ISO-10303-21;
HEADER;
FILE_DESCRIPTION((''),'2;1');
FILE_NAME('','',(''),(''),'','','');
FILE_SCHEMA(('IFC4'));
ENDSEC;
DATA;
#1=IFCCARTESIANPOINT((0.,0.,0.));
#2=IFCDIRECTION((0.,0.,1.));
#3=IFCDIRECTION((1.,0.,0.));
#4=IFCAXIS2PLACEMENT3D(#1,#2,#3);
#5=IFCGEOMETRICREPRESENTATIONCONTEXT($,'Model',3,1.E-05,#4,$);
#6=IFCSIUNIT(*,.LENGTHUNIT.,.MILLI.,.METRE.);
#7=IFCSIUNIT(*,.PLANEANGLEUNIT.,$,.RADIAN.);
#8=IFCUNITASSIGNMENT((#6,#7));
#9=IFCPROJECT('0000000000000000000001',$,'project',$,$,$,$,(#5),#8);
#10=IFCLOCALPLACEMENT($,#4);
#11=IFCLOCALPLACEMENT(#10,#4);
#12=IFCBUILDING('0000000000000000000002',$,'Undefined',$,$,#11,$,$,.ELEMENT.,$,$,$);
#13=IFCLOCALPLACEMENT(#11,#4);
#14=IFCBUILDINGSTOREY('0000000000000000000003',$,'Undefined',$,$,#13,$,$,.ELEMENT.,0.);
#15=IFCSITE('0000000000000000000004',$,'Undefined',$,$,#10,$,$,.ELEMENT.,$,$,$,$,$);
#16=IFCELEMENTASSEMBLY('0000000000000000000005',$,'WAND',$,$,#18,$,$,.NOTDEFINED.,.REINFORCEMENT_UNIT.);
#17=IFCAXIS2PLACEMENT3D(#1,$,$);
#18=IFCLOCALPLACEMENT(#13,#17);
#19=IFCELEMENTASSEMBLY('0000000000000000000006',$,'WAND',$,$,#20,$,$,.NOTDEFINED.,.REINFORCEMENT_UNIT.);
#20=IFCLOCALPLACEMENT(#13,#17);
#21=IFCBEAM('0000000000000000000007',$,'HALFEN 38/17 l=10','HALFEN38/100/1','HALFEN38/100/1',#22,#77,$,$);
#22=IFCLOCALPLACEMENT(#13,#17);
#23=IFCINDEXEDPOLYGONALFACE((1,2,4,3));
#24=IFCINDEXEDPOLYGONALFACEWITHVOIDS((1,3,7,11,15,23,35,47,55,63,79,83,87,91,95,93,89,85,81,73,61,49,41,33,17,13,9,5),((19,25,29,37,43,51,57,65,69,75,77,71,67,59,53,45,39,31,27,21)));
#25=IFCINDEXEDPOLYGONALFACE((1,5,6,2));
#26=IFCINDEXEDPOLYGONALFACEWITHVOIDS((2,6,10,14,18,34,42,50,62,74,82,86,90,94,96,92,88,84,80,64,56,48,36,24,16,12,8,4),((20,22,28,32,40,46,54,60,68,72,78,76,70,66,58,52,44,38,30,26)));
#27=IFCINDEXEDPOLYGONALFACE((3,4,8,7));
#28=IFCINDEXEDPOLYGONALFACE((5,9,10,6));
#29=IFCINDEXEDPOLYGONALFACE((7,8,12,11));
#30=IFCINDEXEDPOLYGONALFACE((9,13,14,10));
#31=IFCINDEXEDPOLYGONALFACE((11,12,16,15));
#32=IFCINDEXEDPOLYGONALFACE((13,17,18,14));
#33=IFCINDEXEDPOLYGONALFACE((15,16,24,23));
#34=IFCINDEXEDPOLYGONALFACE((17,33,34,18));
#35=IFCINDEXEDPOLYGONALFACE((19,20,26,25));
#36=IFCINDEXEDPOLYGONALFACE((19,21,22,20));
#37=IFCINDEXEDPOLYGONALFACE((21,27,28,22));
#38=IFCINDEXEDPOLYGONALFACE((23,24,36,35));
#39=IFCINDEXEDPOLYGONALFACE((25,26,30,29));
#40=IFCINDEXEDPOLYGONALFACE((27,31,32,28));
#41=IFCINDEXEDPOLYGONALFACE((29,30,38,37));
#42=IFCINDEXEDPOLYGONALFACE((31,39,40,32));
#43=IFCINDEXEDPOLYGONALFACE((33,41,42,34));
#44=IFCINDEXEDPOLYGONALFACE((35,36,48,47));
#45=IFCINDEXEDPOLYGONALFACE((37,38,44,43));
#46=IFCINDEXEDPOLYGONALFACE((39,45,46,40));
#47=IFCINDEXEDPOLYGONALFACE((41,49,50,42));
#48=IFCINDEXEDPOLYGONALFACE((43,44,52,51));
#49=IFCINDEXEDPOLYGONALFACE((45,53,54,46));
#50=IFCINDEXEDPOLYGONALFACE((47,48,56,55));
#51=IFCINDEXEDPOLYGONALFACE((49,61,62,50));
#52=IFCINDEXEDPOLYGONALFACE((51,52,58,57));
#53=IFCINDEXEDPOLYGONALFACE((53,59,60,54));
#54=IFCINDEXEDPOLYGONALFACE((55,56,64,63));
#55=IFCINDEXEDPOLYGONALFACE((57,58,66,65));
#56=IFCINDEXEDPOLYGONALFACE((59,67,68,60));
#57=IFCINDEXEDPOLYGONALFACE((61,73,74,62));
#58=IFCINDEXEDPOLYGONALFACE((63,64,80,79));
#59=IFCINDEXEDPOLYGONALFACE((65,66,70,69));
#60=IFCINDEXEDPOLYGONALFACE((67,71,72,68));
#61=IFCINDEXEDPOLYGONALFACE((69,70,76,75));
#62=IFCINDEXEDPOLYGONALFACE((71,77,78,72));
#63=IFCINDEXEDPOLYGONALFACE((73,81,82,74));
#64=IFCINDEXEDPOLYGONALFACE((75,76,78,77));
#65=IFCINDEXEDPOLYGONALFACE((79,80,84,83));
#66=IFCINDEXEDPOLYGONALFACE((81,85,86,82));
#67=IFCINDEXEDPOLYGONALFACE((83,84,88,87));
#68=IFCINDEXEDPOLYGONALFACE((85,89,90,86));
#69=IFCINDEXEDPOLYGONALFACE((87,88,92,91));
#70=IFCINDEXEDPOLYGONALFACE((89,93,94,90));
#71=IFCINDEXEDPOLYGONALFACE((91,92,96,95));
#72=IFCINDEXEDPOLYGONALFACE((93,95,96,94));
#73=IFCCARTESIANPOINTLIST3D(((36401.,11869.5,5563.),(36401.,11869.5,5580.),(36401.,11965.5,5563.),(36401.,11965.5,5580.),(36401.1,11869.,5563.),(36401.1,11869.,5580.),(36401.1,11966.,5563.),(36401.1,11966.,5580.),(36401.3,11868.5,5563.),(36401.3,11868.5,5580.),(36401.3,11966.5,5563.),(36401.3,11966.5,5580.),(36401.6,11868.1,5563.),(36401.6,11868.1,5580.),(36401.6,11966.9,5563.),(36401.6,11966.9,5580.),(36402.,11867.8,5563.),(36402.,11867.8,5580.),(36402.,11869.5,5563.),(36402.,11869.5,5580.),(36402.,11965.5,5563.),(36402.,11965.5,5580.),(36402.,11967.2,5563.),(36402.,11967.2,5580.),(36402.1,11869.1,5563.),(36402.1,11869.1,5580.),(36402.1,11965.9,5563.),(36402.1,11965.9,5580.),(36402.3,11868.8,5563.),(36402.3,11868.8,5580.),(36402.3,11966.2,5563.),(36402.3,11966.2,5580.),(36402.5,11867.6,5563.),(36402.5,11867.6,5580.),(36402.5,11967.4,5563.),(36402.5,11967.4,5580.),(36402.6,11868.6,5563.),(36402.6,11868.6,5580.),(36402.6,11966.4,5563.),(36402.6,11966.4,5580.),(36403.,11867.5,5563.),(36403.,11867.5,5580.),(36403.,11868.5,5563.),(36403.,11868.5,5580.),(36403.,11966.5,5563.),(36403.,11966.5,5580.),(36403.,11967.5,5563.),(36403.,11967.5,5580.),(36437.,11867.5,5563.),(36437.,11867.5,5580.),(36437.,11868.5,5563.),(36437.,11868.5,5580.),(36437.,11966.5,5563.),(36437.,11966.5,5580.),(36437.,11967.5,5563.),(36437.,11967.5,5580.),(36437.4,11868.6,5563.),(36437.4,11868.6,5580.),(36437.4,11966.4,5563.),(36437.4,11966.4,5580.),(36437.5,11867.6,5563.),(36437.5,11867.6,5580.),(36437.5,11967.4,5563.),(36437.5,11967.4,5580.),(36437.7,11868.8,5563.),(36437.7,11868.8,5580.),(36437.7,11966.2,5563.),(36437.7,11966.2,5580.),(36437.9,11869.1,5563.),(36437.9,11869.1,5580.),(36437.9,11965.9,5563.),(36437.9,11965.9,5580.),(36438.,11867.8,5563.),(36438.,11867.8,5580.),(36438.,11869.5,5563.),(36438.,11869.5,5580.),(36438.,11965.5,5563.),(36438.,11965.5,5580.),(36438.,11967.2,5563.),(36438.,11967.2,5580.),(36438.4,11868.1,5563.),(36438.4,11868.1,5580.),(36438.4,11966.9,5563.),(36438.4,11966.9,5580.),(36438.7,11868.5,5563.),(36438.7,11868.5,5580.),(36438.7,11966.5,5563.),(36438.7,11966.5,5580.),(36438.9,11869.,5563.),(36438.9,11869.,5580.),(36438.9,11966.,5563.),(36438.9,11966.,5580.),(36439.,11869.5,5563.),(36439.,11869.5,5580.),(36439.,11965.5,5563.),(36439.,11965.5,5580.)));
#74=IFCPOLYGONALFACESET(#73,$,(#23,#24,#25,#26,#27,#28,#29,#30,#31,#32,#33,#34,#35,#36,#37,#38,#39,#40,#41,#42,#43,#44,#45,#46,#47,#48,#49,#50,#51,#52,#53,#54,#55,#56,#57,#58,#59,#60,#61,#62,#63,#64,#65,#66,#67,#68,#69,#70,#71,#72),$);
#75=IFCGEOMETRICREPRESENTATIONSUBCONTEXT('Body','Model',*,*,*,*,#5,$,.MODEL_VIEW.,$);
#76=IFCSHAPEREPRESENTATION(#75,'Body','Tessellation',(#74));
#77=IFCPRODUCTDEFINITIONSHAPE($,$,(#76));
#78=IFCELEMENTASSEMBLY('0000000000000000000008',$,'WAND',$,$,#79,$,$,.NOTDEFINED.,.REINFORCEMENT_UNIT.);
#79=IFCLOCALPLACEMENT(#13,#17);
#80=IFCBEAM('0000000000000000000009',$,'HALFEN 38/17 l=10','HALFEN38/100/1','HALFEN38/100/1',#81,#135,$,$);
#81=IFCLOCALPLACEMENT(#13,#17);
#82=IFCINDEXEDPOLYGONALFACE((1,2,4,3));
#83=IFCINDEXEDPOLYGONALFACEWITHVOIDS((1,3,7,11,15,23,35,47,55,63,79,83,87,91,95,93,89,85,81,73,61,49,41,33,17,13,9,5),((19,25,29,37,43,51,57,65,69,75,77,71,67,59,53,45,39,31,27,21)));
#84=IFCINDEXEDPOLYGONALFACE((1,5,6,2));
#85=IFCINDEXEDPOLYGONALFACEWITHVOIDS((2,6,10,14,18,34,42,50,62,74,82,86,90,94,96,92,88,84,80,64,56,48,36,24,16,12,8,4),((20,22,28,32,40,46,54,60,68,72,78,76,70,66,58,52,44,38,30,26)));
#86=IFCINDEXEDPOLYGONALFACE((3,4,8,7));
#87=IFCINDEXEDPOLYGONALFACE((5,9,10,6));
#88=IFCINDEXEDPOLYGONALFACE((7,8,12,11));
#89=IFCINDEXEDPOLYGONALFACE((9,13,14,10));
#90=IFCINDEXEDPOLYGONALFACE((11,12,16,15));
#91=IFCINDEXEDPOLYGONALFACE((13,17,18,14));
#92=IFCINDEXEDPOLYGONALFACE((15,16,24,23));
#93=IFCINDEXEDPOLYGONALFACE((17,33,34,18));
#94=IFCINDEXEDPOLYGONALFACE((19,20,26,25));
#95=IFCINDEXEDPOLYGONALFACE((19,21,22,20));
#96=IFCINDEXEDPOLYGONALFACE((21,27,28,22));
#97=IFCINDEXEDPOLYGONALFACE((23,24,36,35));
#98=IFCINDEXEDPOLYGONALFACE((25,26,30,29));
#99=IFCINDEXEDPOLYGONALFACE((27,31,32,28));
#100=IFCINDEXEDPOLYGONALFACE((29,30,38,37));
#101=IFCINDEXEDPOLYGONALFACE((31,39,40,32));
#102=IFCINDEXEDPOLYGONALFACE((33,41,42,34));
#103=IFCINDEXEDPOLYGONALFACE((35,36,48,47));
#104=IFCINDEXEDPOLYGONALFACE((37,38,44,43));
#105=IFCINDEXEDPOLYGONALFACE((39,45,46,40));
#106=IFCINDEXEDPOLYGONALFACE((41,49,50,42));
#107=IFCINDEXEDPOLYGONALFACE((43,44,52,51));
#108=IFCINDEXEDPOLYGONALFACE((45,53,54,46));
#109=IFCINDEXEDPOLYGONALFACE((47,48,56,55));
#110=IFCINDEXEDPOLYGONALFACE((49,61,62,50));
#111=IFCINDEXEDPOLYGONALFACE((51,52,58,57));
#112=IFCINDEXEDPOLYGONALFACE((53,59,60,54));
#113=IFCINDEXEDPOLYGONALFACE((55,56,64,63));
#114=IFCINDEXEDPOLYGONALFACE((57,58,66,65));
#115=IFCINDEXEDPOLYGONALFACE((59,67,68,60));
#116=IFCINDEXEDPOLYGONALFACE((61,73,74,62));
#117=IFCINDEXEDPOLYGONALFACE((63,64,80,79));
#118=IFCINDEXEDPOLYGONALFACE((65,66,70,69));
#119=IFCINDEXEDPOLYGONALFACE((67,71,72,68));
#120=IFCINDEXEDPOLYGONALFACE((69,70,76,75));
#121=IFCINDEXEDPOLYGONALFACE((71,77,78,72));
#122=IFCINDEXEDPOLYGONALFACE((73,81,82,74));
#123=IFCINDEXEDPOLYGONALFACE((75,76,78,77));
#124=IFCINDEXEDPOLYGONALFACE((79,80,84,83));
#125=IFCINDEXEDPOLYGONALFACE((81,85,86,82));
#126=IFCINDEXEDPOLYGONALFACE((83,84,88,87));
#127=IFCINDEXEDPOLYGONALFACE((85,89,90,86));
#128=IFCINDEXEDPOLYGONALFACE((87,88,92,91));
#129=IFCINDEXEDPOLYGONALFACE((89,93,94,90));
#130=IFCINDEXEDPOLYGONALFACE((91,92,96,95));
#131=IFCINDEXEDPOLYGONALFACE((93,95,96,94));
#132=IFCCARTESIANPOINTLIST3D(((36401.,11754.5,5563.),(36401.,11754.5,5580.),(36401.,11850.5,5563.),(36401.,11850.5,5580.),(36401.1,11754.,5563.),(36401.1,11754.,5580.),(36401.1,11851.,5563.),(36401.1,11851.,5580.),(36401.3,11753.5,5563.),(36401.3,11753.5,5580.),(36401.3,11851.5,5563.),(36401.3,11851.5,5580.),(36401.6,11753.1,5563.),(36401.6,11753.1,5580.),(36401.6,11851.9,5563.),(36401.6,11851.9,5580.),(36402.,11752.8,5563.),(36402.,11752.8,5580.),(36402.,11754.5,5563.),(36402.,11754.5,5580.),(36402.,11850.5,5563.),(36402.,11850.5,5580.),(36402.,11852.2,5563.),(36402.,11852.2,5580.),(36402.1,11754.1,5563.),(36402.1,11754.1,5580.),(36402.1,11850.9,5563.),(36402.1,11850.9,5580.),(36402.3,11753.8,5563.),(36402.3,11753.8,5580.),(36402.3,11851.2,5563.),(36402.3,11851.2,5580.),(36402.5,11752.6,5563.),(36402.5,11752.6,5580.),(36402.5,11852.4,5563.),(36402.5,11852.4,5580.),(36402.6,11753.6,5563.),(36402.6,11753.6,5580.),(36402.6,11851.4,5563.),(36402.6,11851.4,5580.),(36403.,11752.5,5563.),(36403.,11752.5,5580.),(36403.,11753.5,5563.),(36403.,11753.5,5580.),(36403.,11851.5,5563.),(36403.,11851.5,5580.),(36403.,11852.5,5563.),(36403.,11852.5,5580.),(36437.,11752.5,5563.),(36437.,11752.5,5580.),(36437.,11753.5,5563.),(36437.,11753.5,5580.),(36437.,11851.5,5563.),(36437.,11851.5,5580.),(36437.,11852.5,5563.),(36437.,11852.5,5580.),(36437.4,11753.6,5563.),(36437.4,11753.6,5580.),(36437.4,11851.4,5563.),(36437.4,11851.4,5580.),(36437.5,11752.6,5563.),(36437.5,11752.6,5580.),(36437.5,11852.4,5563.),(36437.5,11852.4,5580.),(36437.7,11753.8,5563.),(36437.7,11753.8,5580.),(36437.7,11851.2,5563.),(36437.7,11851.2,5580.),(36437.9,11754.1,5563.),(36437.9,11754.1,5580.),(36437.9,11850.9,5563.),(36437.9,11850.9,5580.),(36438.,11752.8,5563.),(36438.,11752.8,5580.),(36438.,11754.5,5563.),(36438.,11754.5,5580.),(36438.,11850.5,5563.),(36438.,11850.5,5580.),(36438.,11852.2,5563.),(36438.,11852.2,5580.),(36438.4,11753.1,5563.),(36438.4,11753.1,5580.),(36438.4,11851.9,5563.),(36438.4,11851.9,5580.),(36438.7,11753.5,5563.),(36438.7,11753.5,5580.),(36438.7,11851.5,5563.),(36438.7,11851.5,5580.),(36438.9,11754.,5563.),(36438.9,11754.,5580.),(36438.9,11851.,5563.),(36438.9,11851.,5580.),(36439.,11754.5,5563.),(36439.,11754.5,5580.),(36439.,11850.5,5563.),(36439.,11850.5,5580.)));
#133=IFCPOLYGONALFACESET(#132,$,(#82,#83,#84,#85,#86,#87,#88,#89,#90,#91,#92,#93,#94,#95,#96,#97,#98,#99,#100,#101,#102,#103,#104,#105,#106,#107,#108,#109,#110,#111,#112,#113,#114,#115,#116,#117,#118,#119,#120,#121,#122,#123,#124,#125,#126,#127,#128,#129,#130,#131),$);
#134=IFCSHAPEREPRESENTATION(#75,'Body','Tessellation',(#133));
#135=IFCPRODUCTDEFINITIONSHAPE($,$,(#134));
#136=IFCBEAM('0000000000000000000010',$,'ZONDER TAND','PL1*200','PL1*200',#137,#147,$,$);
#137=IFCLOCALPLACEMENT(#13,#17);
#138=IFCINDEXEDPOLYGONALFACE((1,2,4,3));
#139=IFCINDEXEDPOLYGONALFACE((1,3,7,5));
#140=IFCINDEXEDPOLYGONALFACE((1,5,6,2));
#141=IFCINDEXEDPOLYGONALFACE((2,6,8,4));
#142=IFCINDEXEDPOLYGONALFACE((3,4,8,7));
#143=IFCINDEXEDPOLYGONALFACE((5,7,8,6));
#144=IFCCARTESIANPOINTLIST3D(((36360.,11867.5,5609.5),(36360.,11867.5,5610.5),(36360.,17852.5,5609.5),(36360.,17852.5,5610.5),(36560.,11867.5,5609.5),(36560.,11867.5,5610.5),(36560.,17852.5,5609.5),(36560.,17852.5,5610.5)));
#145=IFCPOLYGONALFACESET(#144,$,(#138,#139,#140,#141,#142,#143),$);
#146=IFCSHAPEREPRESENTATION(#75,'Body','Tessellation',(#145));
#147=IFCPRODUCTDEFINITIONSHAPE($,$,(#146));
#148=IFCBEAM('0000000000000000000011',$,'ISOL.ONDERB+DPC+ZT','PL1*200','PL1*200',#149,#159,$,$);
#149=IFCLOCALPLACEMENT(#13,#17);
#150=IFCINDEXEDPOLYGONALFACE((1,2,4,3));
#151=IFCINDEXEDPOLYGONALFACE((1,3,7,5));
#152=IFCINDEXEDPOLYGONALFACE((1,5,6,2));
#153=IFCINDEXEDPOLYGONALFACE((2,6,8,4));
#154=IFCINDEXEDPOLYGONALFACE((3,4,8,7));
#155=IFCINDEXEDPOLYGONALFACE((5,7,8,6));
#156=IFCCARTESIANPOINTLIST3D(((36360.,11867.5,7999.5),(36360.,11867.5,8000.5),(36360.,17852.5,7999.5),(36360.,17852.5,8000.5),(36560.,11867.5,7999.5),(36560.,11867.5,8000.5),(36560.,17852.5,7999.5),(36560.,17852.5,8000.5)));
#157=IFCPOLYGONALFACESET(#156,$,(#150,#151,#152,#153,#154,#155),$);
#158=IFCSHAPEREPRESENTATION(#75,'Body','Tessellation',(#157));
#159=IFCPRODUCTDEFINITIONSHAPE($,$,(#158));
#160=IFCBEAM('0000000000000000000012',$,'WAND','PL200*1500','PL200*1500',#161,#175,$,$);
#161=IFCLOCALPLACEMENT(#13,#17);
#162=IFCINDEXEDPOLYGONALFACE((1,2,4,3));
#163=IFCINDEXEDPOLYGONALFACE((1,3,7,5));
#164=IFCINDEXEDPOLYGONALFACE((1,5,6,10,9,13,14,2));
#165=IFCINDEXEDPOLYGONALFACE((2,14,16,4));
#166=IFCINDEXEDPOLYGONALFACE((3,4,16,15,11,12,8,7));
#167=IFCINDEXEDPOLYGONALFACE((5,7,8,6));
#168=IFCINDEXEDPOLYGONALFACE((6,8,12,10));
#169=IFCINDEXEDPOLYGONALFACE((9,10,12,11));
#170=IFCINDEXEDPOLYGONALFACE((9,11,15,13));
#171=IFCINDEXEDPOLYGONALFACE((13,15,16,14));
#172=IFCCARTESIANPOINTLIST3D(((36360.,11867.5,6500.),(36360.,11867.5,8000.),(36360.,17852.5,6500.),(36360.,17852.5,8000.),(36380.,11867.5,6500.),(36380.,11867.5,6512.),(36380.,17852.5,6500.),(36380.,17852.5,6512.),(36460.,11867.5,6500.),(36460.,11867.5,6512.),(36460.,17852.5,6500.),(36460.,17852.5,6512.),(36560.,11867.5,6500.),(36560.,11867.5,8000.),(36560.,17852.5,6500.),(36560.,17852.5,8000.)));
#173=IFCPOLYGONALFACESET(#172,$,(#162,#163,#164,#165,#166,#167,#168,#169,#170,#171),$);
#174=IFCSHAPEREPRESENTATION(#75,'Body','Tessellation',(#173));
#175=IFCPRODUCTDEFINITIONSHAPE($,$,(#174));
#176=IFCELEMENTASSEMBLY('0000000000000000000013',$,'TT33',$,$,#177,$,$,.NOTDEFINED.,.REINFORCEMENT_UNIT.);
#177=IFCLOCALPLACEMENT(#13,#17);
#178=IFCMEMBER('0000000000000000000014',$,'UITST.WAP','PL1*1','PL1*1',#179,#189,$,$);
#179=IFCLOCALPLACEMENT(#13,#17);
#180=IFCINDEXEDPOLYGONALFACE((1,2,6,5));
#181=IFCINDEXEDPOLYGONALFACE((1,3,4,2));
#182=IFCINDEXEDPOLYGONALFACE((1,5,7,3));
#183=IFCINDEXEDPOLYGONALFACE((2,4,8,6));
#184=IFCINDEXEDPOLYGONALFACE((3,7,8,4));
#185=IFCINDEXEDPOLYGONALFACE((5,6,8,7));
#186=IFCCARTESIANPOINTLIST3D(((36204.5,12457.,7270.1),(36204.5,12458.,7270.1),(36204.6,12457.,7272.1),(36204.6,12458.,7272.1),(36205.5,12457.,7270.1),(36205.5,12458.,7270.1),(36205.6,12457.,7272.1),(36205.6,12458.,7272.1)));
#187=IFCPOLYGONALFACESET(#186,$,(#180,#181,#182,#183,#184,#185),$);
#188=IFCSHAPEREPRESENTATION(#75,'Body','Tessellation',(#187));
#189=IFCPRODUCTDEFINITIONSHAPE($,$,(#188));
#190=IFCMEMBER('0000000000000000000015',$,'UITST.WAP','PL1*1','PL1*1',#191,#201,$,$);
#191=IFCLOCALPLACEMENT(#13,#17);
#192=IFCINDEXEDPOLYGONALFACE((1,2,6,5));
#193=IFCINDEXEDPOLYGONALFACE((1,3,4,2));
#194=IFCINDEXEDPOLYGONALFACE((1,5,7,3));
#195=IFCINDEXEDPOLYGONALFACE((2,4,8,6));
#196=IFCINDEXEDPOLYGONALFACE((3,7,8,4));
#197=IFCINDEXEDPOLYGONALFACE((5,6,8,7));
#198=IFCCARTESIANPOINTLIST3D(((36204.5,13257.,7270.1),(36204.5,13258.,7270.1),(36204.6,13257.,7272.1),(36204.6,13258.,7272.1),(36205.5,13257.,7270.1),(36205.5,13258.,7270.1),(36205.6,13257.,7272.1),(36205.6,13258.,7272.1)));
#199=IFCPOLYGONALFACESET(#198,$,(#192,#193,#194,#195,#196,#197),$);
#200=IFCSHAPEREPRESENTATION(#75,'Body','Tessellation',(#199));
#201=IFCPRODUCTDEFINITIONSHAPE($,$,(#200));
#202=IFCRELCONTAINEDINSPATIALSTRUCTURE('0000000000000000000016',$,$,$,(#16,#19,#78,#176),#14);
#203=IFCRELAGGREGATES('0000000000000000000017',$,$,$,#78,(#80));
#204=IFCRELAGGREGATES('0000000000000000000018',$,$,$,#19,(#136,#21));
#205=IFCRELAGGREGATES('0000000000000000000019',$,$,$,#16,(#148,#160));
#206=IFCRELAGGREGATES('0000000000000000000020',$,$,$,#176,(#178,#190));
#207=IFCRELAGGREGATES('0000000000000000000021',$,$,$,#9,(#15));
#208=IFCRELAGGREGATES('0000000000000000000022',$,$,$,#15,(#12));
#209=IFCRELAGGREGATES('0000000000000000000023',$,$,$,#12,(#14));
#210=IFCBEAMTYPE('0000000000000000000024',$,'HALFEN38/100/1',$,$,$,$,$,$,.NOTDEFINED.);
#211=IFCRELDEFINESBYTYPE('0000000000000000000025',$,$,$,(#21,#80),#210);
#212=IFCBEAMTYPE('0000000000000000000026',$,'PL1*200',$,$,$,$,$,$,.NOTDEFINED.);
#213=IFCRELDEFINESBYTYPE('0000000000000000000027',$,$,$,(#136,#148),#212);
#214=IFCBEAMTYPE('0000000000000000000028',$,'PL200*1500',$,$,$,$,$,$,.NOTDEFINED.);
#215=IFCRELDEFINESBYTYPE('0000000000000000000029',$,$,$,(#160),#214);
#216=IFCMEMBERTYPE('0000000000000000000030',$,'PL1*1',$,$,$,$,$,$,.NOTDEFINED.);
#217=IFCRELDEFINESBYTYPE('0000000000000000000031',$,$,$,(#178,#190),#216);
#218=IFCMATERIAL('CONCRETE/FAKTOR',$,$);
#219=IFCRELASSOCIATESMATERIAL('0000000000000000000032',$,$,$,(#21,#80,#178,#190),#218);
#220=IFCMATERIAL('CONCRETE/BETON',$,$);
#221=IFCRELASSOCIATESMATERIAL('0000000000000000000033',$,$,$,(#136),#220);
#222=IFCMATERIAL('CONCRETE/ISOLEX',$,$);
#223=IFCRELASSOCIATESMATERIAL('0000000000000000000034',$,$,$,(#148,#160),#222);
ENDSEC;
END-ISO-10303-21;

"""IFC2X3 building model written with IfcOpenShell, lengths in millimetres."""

from ifc_helpers import new_model, si_unit, frame, frame_2d, origin_with_axes, place, context, subcontext, project, spatial, rectangle, hollow_rectangle, extrude, boolean, material, type_object, element, aggregate, save


model = new_model("IFC2X3")

# Units and contexts
model_context = context("Model", 3, precision=1e-05, world=origin_with_axes())
body_context = subcontext(model_context, "Body", "Model", "MODEL_VIEW")
ifc_project = project(units=[si_unit("LENGTHUNIT", "METRE", prefix="MILLI"), si_unit("PLANEANGLEUNIT", "RADIAN")], contexts=[model_context])

# Site, building, storey
site_placement = place(None, origin_with_axes())
site = spatial("IfcSite", under=ifc_project, at=site_placement, Name="Undefined", CompositionType="ELEMENT")
building_placement = place(site_placement, origin_with_axes())
building = spatial("IfcBuilding", under=site, at=building_placement, Name="Undefined", CompositionType="ELEMENT")
storey_placement = place(building_placement, origin_with_axes())
storey = spatial("IfcBuildingStorey", under=building, at=storey_placement, Name="Undefined", CompositionType="ELEMENT", Elevation=0.0)

# Shared definitions
ifc_material_1 = material(Name="CONCRETE/FAKTOR")
ifc_material_2 = material(Name="CONCRETE/BETON")

# Element assembly
assembly_1_placement = place(storey_placement, origin_with_axes())
assembly_1 = element("IfcElementAssembly", 1, at=assembly_1_placement, inside=storey, Name="WAND", AssemblyPlace="NOTDEFINED", PredefinedType="REINFORCEMENT_UNIT")

# Element assemblies, beams
assembly_2_placement = place(storey_placement, origin_with_axes())
assembly_2 = element("IfcElementAssembly", 2, at=assembly_2_placement, inside=storey, Name="WAND", AssemblyPlace="NOTDEFINED", PredefinedType="REINFORCEMENT_UNIT")
beam_type_1 = type_object("IfcBeamType", Name="HALFEN38/100/1", PredefinedType="NOTDEFINED")
beam_1_placement = place(assembly_2_placement, frame((36420.0, 11917.5, 5580.0), z_axis=(1.0, 0.0, 0.0), x_axis=(0.0, 0.0, -1.0)))
beam_1 = element("IfcBeam", 3, at=beam_1_placement, type_object=beam_type_1, material=ifc_material_1, Name="HALFEN 38/17 l=10", Description="HALFEN38/100/1", ObjectType="HALFEN38/100/1", context=body_context, shape_type="SweptSolid", body=[
    extrude(hollow_rectangle(XDim=100.0, YDim=38.0, WallThickness=1.0, InnerFilletRadius=1.0, OuterFilletRadius=2.0, at=frame_2d((0.0, 0.0), x_axis=(1.0, 0.0))), frame((17.0, 0.0, 0.0), z_axis=(-1.0, 0.0, 0.0), x_axis=(0.0, -1.0, 0.0)), (0.0, 0.0, 1.0), 17.0),
])
assembly_3_placement = place(storey_placement, origin_with_axes())
assembly_3 = element("IfcElementAssembly", 4, at=assembly_3_placement, inside=storey, Name="WAND", AssemblyPlace="NOTDEFINED", PredefinedType="REINFORCEMENT_UNIT")
beam_2_placement = place(assembly_3_placement, frame((36420.0, 11802.5, 5580.0), z_axis=(1.0, 0.0, 0.0), x_axis=(0.0, 0.0, -1.0)))
beam_2 = element("IfcBeam", 5, at=beam_2_placement, type_object=beam_type_1, material=ifc_material_1, Name="HALFEN 38/17 l=10", Description="HALFEN38/100/1", ObjectType="HALFEN38/100/1", context=body_context, shape_type="SweptSolid", body=[
    extrude(hollow_rectangle(XDim=100.0, YDim=38.0, WallThickness=1.0, InnerFilletRadius=1.0, OuterFilletRadius=2.0, at=frame_2d((0.0, 0.0), x_axis=(1.0, 0.0))), frame((17.0, 0.0, 0.0), z_axis=(-1.0, 0.0, 0.0), x_axis=(0.0, -1.0, 0.0)), (0.0, 0.0, 1.0), 17.0),
])
aggregate(assembly_3, [beam_2])

# Beams
beam_type_2 = type_object("IfcBeamType", Name="PL1*200", PredefinedType="NOTDEFINED")
beam_3_placement = place(assembly_2_placement, frame((36460.0, 11867.5, 5610.0), z_axis=(1.0, 0.0, 0.0), x_axis=(0.0, 1.0, 0.0)))
beam_3 = element("IfcBeam", 6, at=beam_3_placement, type_object=beam_type_2, material=ifc_material_2, Name="ZONDER TAND", Description="PL1*200", ObjectType="PL1*200", context=body_context, shape_type="SweptSolid", body=[
    extrude(rectangle(XDim=1.0, YDim=200.0, at=frame_2d((0.0, 0.0), x_axis=(1.0, 0.0))), frame((5985.0, 0.0, 0.0), z_axis=(-1.0, 0.0, 0.0), x_axis=(0.0, -1.0, 0.0)), (0.0, 0.0, 1.0), 5985.0),
])
aggregate(assembly_2, [beam_3, beam_1])
ifc_material_3 = material(Name="CONCRETE/ISOLEX")
beam_4_placement = place(assembly_1_placement, frame((36460.0, 11867.5, 8000.0), z_axis=(1.0, 0.0, 0.0), x_axis=(0.0, 1.0, 0.0)))
beam_4 = element("IfcBeam", 7, at=beam_4_placement, type_object=beam_type_2, material=ifc_material_3, Name="ISOL.ONDERB+DPC+ZT", Description="PL1*200", ObjectType="PL1*200", context=body_context, shape_type="SweptSolid", body=[
    extrude(rectangle(XDim=1.0, YDim=200.0, at=frame_2d((0.0, 0.0), x_axis=(1.0, 0.0))), frame((5985.0, 0.0, 0.0), z_axis=(-1.0, 0.0, 0.0), x_axis=(0.0, -1.0, 0.0)), (0.0, 0.0, 1.0), 5985.0),
])
beam_type_3 = type_object("IfcBeamType", Name="PL200*1500", PredefinedType="NOTDEFINED")
beam_5_placement = place(assembly_1_placement, frame((36460.0, 11867.5, 7250.0), z_axis=(0.0, 0.0, 1.0), x_axis=(0.0, 1.0, 0.0)))
beam_5 = element("IfcBeam", 8, at=beam_5_placement, type_object=beam_type_3, material=ifc_material_3, Name="WAND", Description="PL200*1500", ObjectType="PL200*1500", context=body_context, shape_type="CSG", body=[
    boolean("DIFFERENCE", extrude(rectangle(XDim=200.0, YDim=1500.0, at=frame_2d((0.0, 0.0), x_axis=(1.0, 0.0))), frame((5985.0, 0.0, 0.0), z_axis=(-1.0, 0.0, 0.0), x_axis=(0.0, -1.0, 0.0)), (0.0, 0.0, 1.0), 5985.0), extrude(rectangle(XDim=12.0, YDim=80.0, at=frame_2d((0.0, 0.0), x_axis=(1.0, 0.0))), frame((5985.0, 40.0, -744.0), z_axis=(-1.0, 0.0, 0.0), x_axis=(0.0, 0.0, -1.0)), (0.0, 0.0, 1.0), 5985.0)),
])
aggregate(assembly_1, [beam_4, beam_5])

# Element assembly, members
assembly_4_placement = place(storey_placement, origin_with_axes())
assembly_4 = element("IfcElementAssembly", 9, at=assembly_4_placement, inside=storey, Name="TT33", AssemblyPlace="NOTDEFINED", PredefinedType="REINFORCEMENT_UNIT")
member_type = type_object("IfcMemberType", Name="PL1*1", PredefinedType="NOTDEFINED")
member_1_placement = place(assembly_4_placement, frame((36205.0, 12457.5, 7270.1), z_axis=(0.0, -1.0, 0.0), x_axis=(0.031107, 0.0, 0.999516)))
member_1 = element("IfcMember", 10, at=member_1_placement, type_object=member_type, material=ifc_material_1, Name="UITST.WAP", Description="PL1*1", ObjectType="PL1*1", context=body_context, shape_type="SweptSolid", body=[
    extrude(rectangle(XDim=1.0, YDim=1.0, at=frame_2d((0.0, 0.0), x_axis=(1.0, 0.0))), frame((2.0, 0.0, 0.0), z_axis=(-1.0, 0.0, 0.0), x_axis=(0.0, -1.0, 0.0)), (0.0, 0.0, 1.0), 2.0),
])
member_2_placement = place(assembly_4_placement, frame((36205.0, 13257.5, 7270.1), z_axis=(0.0, -1.0, 0.0), x_axis=(0.031107, 0.0, 0.999516)))
member_2 = element("IfcMember", 11, at=member_2_placement, type_object=member_type, material=ifc_material_1, Name="UITST.WAP", Description="PL1*1", ObjectType="PL1*1", context=body_context, shape_type="SweptSolid", body=[
    extrude(rectangle(XDim=1.0, YDim=1.0, at=frame_2d((0.0, 0.0), x_axis=(1.0, 0.0))), frame((2.0, 0.0, 0.0), z_axis=(-1.0, 0.0, 0.0), x_axis=(0.0, -1.0, 0.0)), (0.0, 0.0, 1.0), 2.0),
])
aggregate(assembly_4, [member_1, member_2])

save(model, "model.ifc")
